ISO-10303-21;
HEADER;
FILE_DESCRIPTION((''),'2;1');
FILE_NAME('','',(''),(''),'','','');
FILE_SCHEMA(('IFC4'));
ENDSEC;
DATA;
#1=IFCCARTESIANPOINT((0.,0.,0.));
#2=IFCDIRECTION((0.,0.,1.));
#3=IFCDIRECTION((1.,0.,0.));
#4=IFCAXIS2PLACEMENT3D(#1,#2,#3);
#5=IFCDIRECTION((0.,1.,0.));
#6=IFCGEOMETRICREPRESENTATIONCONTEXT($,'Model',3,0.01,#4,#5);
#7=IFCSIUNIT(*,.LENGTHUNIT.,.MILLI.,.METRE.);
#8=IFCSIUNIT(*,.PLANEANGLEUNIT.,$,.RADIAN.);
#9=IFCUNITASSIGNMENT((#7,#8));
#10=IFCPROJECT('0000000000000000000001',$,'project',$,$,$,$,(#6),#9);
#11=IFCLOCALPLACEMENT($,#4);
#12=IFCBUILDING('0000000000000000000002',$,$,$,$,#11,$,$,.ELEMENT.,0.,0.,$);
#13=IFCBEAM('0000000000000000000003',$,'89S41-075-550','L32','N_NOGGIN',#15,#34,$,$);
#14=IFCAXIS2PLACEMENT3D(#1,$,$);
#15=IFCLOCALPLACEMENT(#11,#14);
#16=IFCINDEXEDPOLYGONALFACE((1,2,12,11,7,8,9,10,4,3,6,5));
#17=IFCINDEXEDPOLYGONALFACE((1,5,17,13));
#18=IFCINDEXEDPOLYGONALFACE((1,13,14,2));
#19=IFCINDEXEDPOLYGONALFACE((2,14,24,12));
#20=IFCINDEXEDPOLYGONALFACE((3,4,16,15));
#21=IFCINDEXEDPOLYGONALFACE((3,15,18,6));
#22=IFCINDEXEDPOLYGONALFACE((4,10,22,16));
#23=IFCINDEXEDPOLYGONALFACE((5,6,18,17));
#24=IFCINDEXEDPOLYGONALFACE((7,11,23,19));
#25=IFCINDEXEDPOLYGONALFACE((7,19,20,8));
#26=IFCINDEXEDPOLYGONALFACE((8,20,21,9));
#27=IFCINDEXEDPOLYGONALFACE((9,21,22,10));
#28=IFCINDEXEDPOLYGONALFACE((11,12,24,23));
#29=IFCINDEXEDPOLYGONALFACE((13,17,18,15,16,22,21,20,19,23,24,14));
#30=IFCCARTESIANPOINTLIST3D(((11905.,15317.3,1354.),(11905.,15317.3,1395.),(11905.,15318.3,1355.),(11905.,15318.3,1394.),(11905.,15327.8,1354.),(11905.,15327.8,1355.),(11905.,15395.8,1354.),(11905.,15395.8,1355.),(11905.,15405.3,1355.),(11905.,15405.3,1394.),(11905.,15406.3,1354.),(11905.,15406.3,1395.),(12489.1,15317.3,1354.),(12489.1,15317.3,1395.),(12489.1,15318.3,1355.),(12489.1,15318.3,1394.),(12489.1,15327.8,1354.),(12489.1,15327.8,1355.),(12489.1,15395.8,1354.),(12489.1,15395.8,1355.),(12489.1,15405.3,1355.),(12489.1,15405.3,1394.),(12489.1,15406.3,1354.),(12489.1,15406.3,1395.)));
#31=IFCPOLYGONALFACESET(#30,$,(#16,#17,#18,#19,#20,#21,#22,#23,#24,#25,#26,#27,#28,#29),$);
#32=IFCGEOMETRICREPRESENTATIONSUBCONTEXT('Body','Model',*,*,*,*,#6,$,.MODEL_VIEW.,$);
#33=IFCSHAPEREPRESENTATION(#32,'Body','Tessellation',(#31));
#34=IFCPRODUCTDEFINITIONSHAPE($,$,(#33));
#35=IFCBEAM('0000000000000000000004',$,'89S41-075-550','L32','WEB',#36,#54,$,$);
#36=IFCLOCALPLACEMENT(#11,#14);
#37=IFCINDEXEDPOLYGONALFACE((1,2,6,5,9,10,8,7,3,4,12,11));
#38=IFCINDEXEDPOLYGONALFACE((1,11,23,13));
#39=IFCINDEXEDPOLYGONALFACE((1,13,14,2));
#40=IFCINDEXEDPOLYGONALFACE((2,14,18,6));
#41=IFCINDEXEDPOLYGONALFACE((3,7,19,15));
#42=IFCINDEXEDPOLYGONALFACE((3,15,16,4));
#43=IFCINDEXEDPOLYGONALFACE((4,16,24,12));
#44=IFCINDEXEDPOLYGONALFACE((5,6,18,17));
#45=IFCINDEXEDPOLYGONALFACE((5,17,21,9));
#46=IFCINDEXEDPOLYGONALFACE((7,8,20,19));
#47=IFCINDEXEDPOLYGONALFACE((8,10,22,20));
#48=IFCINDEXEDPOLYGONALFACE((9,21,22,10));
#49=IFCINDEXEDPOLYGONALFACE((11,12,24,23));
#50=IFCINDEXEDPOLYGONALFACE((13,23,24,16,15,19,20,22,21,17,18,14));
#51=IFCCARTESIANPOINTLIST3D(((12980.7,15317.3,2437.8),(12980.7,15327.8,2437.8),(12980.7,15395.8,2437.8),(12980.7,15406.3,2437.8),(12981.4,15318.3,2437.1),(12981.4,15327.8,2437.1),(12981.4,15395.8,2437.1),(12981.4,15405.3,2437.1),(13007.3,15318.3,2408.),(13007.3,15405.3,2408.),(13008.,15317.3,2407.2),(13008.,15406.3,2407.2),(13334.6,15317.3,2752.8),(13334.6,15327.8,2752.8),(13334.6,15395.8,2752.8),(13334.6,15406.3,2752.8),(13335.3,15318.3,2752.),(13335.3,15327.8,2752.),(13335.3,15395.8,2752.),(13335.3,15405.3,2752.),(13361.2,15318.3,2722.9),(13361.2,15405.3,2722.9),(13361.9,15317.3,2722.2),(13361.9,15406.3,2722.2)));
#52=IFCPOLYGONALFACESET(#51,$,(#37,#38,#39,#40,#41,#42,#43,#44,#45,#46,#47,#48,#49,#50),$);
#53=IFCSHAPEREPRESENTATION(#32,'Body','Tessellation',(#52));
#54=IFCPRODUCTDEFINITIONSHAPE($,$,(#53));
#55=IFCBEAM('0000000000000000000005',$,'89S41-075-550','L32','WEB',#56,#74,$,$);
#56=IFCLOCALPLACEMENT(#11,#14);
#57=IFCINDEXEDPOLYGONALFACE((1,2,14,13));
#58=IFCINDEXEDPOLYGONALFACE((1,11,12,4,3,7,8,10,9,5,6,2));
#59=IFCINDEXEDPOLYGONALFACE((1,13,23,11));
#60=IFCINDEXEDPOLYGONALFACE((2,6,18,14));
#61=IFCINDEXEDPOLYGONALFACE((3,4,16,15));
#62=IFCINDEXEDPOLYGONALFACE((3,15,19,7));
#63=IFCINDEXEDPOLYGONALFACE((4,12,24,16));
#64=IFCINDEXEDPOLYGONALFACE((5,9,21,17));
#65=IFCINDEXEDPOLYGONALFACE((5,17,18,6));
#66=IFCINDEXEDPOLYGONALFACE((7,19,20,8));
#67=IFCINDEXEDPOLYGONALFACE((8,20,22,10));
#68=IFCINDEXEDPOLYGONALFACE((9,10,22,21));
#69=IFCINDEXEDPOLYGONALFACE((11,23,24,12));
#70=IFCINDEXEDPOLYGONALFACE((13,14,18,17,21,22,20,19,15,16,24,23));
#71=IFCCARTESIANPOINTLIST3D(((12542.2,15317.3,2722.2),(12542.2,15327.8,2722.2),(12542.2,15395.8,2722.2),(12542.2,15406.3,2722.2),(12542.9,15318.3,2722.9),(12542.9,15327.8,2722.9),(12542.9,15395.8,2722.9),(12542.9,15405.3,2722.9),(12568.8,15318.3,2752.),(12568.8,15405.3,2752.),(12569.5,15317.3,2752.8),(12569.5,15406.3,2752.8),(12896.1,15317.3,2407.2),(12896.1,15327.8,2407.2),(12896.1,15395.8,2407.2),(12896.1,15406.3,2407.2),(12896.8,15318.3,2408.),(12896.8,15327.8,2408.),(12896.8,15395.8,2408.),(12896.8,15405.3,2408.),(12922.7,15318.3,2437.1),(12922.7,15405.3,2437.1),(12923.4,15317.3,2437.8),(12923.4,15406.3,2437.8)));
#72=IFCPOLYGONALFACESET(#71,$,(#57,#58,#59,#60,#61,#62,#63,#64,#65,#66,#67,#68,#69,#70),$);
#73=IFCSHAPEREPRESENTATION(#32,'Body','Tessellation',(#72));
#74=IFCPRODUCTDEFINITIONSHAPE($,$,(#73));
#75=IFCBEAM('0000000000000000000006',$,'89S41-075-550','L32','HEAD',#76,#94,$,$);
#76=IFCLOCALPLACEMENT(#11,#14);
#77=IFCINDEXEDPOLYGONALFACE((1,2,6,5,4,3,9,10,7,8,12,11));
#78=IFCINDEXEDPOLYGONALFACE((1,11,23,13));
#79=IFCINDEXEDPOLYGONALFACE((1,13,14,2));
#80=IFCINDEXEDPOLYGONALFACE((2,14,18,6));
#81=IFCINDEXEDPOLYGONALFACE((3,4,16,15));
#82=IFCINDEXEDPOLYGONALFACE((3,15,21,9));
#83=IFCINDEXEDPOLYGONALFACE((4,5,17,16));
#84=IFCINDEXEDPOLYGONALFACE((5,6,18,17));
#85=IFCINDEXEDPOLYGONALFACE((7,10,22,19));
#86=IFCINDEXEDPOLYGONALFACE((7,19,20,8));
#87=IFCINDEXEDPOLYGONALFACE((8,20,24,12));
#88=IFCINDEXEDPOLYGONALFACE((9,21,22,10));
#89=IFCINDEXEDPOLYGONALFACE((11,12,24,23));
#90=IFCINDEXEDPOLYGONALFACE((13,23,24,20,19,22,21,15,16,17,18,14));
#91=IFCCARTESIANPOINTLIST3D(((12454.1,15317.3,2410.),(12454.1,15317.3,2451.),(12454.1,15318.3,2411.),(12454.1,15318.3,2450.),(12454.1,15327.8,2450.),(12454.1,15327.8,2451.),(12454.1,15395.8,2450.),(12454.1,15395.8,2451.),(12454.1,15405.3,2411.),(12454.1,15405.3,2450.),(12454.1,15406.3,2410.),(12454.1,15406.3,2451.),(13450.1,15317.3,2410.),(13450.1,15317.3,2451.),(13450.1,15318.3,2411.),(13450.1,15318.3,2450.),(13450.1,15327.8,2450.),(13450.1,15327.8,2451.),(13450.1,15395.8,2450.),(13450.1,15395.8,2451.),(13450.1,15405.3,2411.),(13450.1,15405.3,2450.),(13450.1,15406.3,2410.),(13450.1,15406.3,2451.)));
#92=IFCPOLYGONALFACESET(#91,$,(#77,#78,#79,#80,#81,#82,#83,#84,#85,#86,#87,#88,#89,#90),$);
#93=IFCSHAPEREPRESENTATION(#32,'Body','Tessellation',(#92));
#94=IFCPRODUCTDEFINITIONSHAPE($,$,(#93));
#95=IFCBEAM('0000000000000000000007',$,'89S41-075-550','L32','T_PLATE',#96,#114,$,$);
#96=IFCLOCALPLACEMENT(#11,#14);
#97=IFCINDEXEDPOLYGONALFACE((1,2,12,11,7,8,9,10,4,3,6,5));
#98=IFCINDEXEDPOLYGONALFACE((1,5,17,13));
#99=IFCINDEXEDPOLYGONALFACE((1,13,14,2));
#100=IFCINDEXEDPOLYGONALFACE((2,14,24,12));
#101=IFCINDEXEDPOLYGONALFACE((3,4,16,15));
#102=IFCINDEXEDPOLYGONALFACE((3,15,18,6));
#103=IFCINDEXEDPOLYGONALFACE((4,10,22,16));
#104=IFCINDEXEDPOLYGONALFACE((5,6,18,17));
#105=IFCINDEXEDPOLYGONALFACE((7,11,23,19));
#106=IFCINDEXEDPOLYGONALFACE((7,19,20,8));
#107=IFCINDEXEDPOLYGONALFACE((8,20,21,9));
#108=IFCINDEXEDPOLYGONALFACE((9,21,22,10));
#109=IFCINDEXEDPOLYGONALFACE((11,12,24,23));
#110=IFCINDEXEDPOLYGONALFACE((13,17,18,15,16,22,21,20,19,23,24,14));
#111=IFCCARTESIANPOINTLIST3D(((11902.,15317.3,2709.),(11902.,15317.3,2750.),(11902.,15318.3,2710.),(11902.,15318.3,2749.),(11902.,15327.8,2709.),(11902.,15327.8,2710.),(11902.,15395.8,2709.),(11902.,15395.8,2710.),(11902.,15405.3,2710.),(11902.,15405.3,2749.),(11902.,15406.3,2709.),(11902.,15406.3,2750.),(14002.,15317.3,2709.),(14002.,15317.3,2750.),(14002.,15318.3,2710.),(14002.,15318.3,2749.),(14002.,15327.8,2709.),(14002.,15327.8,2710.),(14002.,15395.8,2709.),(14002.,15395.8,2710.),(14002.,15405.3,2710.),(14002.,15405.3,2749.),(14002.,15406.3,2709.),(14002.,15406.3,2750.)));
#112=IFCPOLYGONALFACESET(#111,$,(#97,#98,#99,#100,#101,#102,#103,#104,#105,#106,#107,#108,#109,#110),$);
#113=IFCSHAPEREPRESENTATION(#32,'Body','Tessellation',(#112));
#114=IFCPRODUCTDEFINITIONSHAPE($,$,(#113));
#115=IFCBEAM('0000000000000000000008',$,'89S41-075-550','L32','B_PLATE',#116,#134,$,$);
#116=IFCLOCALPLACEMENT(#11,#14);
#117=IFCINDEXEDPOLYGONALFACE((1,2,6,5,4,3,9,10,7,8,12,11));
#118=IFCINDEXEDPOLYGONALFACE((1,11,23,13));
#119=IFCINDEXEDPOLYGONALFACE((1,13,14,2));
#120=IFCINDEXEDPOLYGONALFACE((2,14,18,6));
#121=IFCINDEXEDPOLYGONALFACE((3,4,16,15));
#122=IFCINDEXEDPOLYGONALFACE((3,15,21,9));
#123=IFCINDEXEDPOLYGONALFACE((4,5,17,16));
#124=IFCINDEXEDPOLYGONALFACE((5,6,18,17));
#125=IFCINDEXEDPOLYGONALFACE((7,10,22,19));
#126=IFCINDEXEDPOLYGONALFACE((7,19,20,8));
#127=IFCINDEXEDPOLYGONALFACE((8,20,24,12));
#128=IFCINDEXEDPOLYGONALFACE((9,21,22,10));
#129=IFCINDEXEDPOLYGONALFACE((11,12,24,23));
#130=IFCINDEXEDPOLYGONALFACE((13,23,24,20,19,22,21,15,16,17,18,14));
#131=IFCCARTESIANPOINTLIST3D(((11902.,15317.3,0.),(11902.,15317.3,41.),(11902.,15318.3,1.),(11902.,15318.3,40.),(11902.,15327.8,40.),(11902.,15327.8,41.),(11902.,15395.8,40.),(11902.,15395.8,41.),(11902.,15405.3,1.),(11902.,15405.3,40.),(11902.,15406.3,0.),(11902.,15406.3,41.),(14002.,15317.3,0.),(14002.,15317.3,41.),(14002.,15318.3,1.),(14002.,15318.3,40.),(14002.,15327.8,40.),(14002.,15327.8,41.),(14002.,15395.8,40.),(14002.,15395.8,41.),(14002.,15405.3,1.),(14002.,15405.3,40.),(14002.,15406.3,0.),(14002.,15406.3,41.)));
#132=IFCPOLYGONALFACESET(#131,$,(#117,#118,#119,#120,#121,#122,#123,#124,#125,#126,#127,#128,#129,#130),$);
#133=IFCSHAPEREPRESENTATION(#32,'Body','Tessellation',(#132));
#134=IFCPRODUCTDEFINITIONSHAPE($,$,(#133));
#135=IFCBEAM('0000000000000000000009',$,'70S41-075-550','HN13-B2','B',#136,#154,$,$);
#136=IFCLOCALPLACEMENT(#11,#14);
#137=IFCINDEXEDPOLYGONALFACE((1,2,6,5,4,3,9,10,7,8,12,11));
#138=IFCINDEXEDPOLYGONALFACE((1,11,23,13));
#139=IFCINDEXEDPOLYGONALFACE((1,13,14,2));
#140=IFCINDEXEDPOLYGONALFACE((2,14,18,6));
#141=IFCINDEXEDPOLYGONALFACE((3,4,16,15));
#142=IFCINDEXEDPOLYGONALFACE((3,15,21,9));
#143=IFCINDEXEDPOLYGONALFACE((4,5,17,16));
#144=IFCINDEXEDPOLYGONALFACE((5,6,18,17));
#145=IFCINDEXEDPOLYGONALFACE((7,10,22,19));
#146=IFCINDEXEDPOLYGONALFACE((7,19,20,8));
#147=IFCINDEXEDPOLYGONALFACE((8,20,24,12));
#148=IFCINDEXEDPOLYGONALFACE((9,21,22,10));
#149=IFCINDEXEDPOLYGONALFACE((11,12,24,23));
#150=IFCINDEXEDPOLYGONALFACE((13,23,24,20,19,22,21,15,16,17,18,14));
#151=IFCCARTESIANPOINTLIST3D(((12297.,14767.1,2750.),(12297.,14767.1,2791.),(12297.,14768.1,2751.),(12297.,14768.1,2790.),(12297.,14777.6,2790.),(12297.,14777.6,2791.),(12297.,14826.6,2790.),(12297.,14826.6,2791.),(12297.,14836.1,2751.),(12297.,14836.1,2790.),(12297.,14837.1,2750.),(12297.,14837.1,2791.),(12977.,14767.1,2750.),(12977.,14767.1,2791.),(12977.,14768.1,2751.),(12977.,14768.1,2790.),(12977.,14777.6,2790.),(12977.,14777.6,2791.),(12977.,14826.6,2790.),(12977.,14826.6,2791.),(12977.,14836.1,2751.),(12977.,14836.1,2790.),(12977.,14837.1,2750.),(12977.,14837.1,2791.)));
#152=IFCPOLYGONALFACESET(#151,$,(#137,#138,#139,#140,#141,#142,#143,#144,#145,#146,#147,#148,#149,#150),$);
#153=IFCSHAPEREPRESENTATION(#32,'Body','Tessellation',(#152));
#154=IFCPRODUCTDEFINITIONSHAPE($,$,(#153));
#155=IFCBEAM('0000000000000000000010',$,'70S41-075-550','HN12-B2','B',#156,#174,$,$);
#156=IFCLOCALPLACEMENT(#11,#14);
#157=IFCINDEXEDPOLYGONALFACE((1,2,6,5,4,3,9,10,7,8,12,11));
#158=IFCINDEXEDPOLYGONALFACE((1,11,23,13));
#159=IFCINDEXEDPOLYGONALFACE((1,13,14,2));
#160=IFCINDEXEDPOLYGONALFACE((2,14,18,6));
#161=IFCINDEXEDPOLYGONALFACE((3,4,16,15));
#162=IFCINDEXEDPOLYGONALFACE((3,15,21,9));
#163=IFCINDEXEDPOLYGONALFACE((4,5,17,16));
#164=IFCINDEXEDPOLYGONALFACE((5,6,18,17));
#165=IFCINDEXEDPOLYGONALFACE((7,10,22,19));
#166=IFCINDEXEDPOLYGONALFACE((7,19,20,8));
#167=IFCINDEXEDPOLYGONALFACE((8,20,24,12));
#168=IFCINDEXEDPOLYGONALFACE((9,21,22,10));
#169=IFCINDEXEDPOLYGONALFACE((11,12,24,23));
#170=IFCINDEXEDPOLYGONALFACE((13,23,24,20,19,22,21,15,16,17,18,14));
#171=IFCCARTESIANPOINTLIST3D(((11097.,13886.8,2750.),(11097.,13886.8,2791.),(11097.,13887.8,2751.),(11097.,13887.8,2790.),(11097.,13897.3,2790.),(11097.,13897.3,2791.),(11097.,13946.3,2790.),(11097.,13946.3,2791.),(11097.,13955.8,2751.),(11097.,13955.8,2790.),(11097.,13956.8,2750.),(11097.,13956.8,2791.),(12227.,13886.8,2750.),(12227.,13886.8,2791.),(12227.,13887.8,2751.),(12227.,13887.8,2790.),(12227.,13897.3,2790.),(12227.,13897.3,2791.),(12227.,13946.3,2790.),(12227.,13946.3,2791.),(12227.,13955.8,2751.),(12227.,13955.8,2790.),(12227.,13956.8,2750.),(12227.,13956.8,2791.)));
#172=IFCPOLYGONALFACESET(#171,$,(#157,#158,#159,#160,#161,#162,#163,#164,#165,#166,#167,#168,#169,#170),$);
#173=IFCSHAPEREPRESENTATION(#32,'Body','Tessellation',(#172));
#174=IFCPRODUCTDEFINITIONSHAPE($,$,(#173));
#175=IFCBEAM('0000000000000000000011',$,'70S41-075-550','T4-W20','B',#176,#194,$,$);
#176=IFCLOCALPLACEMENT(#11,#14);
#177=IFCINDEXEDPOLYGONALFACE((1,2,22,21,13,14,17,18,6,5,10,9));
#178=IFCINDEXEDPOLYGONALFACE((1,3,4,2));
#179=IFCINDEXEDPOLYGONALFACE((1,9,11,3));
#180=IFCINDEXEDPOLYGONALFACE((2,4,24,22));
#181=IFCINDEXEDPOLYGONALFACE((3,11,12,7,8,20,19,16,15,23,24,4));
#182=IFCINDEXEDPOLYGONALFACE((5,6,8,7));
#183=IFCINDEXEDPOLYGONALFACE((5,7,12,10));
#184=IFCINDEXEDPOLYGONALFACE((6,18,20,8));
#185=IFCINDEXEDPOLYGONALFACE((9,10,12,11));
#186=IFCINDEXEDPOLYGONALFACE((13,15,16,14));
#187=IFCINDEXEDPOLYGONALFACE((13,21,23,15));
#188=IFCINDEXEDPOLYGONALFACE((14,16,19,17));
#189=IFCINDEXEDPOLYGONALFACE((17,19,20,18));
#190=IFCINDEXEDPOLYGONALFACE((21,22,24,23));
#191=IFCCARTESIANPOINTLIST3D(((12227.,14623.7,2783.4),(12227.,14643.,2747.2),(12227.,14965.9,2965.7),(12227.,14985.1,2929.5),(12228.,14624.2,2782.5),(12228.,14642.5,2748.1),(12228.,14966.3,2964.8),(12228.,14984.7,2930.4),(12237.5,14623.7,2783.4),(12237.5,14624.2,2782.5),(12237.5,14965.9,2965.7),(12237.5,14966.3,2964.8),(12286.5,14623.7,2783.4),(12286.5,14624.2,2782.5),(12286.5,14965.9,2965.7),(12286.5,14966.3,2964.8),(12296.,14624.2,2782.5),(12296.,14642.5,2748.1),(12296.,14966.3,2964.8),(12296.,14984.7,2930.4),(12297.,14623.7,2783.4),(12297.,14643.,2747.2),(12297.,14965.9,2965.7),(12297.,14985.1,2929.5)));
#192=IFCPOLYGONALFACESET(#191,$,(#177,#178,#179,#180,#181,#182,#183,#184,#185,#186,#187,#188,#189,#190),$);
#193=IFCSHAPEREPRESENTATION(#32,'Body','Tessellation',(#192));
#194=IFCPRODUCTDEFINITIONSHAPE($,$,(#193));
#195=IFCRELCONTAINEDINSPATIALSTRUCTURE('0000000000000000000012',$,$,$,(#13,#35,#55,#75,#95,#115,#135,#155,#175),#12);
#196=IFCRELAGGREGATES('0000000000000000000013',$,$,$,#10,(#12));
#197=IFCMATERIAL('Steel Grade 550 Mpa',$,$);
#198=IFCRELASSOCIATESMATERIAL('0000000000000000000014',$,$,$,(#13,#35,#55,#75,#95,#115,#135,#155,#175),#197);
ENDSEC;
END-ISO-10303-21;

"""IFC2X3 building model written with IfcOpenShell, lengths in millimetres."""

from ifc_helpers import new_model, si_unit, direction, frame, origin, origin_with_axes, origin_2d_with_axis, place, context, subcontext, project, spatial, c_section, extrude, source, transform, mapped, material, element, save


model = new_model("IFC2X3")

# Units and contexts
model_context = context("Model", 3, precision=0.01, world=origin_with_axes(), true_north=direction((0.0, 1.0, 0.0)))
body_context = subcontext(model_context, "Body", "Model", "MODEL_VIEW")
ifc_project = project(units=[si_unit("LENGTHUNIT", "METRE", prefix="MILLI"), si_unit("PLANEANGLEUNIT", "RADIAN")], contexts=[model_context])

# Building
building_placement = place(None, origin_with_axes())
building = spatial("IfcBuilding", under=ifc_project, at=building_placement, CompositionType="ELEMENT", ElevationOfRefHeight=0.0, ElevationOfTerrain=0.0)

# Shared definitions
ifc_material = material(Name="Steel Grade 550 Mpa")

# Beams
shared_shape_1 = source(origin(), body_context, "Body", "SweptSolid", [
    extrude(c_section(Depth=89.0, Width=41.0, WallThickness=1.0, Girth=10.5, at=origin_2d_with_axis()), origin_with_axes(), (0.0, 0.0, 1.0), 584.0),
])
beam_1_placement = place(None, frame((11905.0, 15361.8, 1374.5), z_axis=(1.0, 0.0, 0.0), x_axis=(0.0, 0.0, -1.0)))
element("IfcBeam", 1, at=beam_1_placement, inside=building, material=ifc_material, Name="89S41-075-550", Description="L32", ObjectType="N_NOGGIN", context=body_context, shape_type="MappedRepresentation", body=[
    mapped(shared_shape_1, transform((0.0, 0.0, 0.0), scale=1.0)),
])
shared_shape_2 = source(origin(), body_context, "Body", "SweptSolid", [
    extrude(c_section(Depth=89.0, Width=41.0, WallThickness=1.0, Girth=10.5, at=origin_2d_with_axis()), origin_with_axes(), (0.0, 0.0, 1.0), 473.8),
])
beam_2_placement = place(None, frame((12994.3, 15361.8, 2422.5), z_axis=(0.747035, 0.0, 0.664785), x_axis=(-0.664785, 0.0, 0.747035)))
element("IfcBeam", 2, at=beam_2_placement, inside=building, material=ifc_material, Name="89S41-075-550", Description="L32", ObjectType="WEB", context=body_context, shape_type="MappedRepresentation", body=[
    mapped(shared_shape_2, transform((0.0, 0.0, 0.0), scale=1.0)),
])
shared_shape_3 = source(origin(), body_context, "Body", "SweptSolid", [
    extrude(c_section(Depth=89.0, Width=41.0, WallThickness=1.0, Girth=10.5, at=origin_2d_with_axis()), origin_with_axes(), (0.0, 0.0, 1.0), 473.8),
])
beam_3_placement = place(None, frame((12909.8, 15361.8, 2422.5), z_axis=(-0.747048, 0.0, 0.664771), x_axis=(-0.664771, 0.0, -0.747048)))
element("IfcBeam", 3, at=beam_3_placement, inside=building, material=ifc_material, Name="89S41-075-550", Description="L32", ObjectType="WEB", context=body_context, shape_type="MappedRepresentation", body=[
    mapped(shared_shape_3, transform((0.0, 0.0, 0.0), scale=1.0)),
])
shared_shape_4 = source(origin(), body_context, "Body", "SweptSolid", [
    extrude(c_section(Depth=89.0, Width=41.0, WallThickness=1.0, Girth=10.5, at=origin_2d_with_axis()), origin_with_axes(), (0.0, 0.0, 1.0), 996.0),
])
beam_4_placement = place(None, frame((12454.1, 15361.8, 2430.5), z_axis=(1.0, 0.0, 0.0), x_axis=(0.0, 0.0, 1.0)))
element("IfcBeam", 4, at=beam_4_placement, inside=building, material=ifc_material, Name="89S41-075-550", Description="L32", ObjectType="HEAD", context=body_context, shape_type="MappedRepresentation", body=[
    mapped(shared_shape_4, transform((0.0, 0.0, 0.0), scale=1.0)),
])
shared_shape_5 = source(origin(), body_context, "Body", "SweptSolid", [
    extrude(c_section(Depth=89.0, Width=41.0, WallThickness=1.0, Girth=10.5, at=origin_2d_with_axis()), origin_with_axes(), (0.0, 0.0, 1.0), 2100.0),
])
beam_5_placement = place(None, frame((11902.0, 15361.8, 2729.5), z_axis=(1.0, 0.0, 0.0), x_axis=(0.0, 0.0, -1.0)))
element("IfcBeam", 5, at=beam_5_placement, inside=building, material=ifc_material, Name="89S41-075-550", Description="L32", ObjectType="T_PLATE", context=body_context, shape_type="MappedRepresentation", body=[
    mapped(shared_shape_5, transform((0.0, 0.0, 0.0), scale=1.0)),
])
shared_shape_6 = source(origin(), body_context, "Body", "SweptSolid", [
    extrude(c_section(Depth=89.0, Width=41.0, WallThickness=1.0, Girth=10.5, at=origin_2d_with_axis()), origin_with_axes(), (0.0, 0.0, 1.0), 2100.0),
])
beam_6_placement = place(None, frame((11902.0, 15361.8, 20.5), z_axis=(1.0, 0.0, 0.0), x_axis=(0.0, 0.0, 1.0)))
element("IfcBeam", 6, at=beam_6_placement, inside=building, material=ifc_material, Name="89S41-075-550", Description="L32", ObjectType="B_PLATE", context=body_context, shape_type="MappedRepresentation", body=[
    mapped(shared_shape_6, transform((0.0, 0.0, 0.0), scale=1.0)),
])
shared_shape_7 = source(origin(), body_context, "Body", "SweptSolid", [
    extrude(c_section(Depth=70.0, Width=41.0, WallThickness=1.0, Girth=10.5, at=origin_2d_with_axis()), origin_with_axes(), (0.0, 0.0, 1.0), 680.0),
])
beam_7_placement = place(None, frame((12977.0, 14802.1, 2770.5), z_axis=(-1.0, 0.0, 0.0), x_axis=(0.0, 0.0, 1.0)))
element("IfcBeam", 7, at=beam_7_placement, inside=building, material=ifc_material, Name="70S41-075-550", Description="HN13-B2", ObjectType="B", context=body_context, shape_type="MappedRepresentation", body=[
    mapped(shared_shape_7, transform((0.0, 0.0, 0.0), scale=1.0)),
])
shared_shape_8 = source(origin(), body_context, "Body", "SweptSolid", [
    extrude(c_section(Depth=70.0, Width=41.0, WallThickness=1.0, Girth=10.5, at=origin_2d_with_axis()), origin_with_axes(), (0.0, 0.0, 1.0), 1130.0),
])
beam_8_placement = place(None, frame((12227.0, 13921.8, 2770.5), z_axis=(-1.0, 0.0, 0.0), x_axis=(0.0, 0.0, 1.0)))
element("IfcBeam", 8, at=beam_8_placement, inside=building, material=ifc_material, Name="70S41-075-550", Description="HN12-B2", ObjectType="B", context=body_context, shape_type="MappedRepresentation", body=[
    mapped(shared_shape_8, transform((0.0, 0.0, 0.0), scale=1.0)),
])
shared_shape_9 = source(origin(), body_context, "Body", "SweptSolid", [
    extrude(c_section(Depth=70.0, Width=41.0, WallThickness=1.0, Girth=10.5, at=origin_2d_with_axis()), origin_with_axes(), (0.0, 0.0, 1.0), 387.7),
])
beam_9_placement = place(None, frame((12262.0, 14633.3, 2765.3), z_axis=(0.0, 0.882622, 0.470083), x_axis=(0.0, -0.470083, 0.882622)))
element("IfcBeam", 9, at=beam_9_placement, inside=building, material=ifc_material, Name="70S41-075-550", Description="T4-W20", ObjectType="B", context=body_context, shape_type="MappedRepresentation", body=[
    mapped(shared_shape_9, transform((0.0, 0.0, 0.0), scale=1.0)),
])

save(model, "model.ifc")
